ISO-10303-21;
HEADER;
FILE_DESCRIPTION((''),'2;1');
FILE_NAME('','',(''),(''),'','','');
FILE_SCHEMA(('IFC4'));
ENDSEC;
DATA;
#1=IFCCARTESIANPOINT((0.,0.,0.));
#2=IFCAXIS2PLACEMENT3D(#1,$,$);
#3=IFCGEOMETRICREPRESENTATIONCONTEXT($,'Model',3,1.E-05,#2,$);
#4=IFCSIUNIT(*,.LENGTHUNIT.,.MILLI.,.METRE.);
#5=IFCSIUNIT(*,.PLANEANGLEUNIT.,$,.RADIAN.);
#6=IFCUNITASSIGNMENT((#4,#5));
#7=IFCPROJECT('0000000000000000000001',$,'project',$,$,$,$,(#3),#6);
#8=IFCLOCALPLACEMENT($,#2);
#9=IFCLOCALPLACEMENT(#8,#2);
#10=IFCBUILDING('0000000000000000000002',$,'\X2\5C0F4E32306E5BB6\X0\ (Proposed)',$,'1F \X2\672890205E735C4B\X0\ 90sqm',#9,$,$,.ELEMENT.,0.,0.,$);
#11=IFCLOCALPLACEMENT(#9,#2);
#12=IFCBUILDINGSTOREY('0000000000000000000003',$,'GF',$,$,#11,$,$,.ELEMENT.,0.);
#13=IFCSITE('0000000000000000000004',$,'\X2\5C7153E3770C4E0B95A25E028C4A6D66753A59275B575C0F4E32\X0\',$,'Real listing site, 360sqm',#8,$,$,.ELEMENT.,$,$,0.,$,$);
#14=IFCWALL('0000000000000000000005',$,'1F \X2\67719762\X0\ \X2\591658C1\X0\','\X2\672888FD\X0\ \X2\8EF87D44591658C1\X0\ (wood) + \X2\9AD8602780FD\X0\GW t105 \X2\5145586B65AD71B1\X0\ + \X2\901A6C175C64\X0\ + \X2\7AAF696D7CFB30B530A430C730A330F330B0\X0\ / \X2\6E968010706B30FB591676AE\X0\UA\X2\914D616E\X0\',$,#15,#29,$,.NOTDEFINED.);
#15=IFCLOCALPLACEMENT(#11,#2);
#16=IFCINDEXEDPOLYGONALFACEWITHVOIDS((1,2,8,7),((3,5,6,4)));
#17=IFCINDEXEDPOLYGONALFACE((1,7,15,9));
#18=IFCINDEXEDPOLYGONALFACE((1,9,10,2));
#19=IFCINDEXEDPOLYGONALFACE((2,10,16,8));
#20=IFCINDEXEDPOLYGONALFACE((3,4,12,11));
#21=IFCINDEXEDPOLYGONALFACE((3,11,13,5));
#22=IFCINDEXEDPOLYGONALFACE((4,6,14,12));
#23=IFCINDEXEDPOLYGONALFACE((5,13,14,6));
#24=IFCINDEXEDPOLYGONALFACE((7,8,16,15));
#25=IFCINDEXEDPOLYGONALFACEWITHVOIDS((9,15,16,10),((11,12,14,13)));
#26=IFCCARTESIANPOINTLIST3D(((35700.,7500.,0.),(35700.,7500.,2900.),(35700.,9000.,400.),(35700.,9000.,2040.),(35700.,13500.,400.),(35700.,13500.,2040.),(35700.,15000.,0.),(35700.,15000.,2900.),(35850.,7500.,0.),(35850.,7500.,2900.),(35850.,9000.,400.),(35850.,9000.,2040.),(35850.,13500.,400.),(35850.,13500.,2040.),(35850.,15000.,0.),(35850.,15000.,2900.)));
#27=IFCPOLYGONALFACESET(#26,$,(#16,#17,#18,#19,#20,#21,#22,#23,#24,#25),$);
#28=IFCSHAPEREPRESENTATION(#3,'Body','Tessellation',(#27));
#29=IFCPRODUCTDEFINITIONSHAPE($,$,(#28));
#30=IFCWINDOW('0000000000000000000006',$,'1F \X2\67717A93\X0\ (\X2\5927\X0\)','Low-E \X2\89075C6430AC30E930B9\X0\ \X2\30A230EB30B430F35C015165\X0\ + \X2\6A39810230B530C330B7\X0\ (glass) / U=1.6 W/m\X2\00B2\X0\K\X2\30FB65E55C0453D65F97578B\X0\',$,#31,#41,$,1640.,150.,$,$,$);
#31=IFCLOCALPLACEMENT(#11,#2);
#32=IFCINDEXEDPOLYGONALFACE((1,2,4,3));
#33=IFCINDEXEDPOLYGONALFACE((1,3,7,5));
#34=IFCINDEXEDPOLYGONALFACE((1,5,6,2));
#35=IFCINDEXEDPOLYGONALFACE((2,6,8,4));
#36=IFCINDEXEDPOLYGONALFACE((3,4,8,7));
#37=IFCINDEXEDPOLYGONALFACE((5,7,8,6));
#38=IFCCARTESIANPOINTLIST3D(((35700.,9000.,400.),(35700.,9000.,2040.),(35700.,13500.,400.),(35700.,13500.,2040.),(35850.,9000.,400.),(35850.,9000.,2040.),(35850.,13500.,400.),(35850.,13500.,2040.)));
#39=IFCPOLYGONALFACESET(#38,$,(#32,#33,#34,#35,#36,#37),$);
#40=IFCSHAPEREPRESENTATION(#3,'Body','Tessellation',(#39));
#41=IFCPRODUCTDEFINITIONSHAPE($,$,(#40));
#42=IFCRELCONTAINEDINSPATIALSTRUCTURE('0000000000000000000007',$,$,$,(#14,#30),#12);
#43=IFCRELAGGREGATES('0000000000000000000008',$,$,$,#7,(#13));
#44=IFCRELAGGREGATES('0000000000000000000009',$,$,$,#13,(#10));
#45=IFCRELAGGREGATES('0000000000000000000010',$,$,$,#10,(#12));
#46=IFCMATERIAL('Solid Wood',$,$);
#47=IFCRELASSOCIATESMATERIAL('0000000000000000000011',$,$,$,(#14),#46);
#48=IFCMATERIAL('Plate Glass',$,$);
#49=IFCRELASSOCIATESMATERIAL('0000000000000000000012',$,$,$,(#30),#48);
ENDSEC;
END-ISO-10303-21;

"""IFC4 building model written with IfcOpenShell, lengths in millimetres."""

from ifc_helpers import new_model, si_unit, frame, frame_2d, origin, place, context, project, spatial, rectangle, extrude, material, element, fill, save


model = new_model("IFC4")

# Units and contexts
model_context = context("Model", 3, precision=1e-05, world=origin())
ifc_project = project(units=[si_unit("LENGTHUNIT", "METRE", prefix="MILLI"), si_unit("PLANEANGLEUNIT", "RADIAN")], contexts=[model_context])

# Site, building, storey
site_placement = place(None, origin())
site = spatial("IfcSite", under=ifc_project, at=site_placement, Name="山口県下関市豊浦町大字小串", ObjectType="Real listing site, 360sqm", CompositionType="ELEMENT", RefElevation=0.0)
building_placement = place(site_placement, origin())
building = spatial("IfcBuilding", under=site, at=building_placement, Name="小串の家 (Proposed)", ObjectType="1F 木造平屋 90sqm", CompositionType="ELEMENT", ElevationOfRefHeight=0.0, ElevationOfTerrain=0.0)
storey_placement = place(building_placement, origin())
storey = spatial("IfcBuildingStorey", under=building, at=storey_placement, Name="GF", CompositionType="ELEMENT", Elevation=0.0)

# Wall, opening, window
ifc_material_1 = material(Name="Solid Wood")
wall_1_placement = place(storey_placement, frame((17850.0, 3750.0, 0.0)))
wall_1 = element("IfcWall", 1, at=wall_1_placement, inside=storey, material=ifc_material_1, Name="1F 東面 外壁", Description="木製 軸組外壁 (wood) + 高性能GW t105 充填断熱 + 通気層 + 窯業系サイディング / 準耐火・外皮UA配慮", PredefinedType="NOTDEFINED", context=model_context, shape_type="SweptSolid", body=[
    extrude(rectangle(XDim=150.0, YDim=7500.0, at=frame_2d((75.0, 3750.0))), frame((17850.0, 3750.0, 0.0)), (0.0, 0.0, 1.0), 2900.0),
])
opening_placement = place(storey_placement, frame((17850.0, 4500.0, 200.0)))
opening = element("IfcOpeningElement", 2, at=opening_placement, cuts=wall_1, PredefinedType="NOTDEFINED", context=model_context, shape_type="SweptSolid", body=[
    extrude(rectangle(XDim=150.0, YDim=4500.0, at=frame_2d((75.0, 2250.0))), frame((17850.0, 4500.0, 200.0)), (0.0, 0.0, 1.0), 1640.0),
])
ifc_material_2 = material(Name="Plate Glass")
window_1_placement = place(storey_placement, frame((17850.0, 4500.0, 200.0)))
window_1 = element("IfcWindow", 3, at=window_1_placement, inside=storey, material=ifc_material_2, Name="1F 東窓 (大)", Description="Low-E 複層ガラス アルゴン封入 + 樹脂サッシ (glass) / U=1.6 W/m²K・日射取得型", OverallHeight=1640.0, OverallWidth=150.0, context=model_context, shape_type="SweptSolid", body=[
    extrude(rectangle(XDim=150.0, YDim=4500.0, at=frame_2d((75.0, 2250.0))), frame((17850.0, 4500.0, 200.0)), (0.0, 0.0, 1.0), 1640.0),
])
fill(opening, window_1)

save(model, "model.ifc")
